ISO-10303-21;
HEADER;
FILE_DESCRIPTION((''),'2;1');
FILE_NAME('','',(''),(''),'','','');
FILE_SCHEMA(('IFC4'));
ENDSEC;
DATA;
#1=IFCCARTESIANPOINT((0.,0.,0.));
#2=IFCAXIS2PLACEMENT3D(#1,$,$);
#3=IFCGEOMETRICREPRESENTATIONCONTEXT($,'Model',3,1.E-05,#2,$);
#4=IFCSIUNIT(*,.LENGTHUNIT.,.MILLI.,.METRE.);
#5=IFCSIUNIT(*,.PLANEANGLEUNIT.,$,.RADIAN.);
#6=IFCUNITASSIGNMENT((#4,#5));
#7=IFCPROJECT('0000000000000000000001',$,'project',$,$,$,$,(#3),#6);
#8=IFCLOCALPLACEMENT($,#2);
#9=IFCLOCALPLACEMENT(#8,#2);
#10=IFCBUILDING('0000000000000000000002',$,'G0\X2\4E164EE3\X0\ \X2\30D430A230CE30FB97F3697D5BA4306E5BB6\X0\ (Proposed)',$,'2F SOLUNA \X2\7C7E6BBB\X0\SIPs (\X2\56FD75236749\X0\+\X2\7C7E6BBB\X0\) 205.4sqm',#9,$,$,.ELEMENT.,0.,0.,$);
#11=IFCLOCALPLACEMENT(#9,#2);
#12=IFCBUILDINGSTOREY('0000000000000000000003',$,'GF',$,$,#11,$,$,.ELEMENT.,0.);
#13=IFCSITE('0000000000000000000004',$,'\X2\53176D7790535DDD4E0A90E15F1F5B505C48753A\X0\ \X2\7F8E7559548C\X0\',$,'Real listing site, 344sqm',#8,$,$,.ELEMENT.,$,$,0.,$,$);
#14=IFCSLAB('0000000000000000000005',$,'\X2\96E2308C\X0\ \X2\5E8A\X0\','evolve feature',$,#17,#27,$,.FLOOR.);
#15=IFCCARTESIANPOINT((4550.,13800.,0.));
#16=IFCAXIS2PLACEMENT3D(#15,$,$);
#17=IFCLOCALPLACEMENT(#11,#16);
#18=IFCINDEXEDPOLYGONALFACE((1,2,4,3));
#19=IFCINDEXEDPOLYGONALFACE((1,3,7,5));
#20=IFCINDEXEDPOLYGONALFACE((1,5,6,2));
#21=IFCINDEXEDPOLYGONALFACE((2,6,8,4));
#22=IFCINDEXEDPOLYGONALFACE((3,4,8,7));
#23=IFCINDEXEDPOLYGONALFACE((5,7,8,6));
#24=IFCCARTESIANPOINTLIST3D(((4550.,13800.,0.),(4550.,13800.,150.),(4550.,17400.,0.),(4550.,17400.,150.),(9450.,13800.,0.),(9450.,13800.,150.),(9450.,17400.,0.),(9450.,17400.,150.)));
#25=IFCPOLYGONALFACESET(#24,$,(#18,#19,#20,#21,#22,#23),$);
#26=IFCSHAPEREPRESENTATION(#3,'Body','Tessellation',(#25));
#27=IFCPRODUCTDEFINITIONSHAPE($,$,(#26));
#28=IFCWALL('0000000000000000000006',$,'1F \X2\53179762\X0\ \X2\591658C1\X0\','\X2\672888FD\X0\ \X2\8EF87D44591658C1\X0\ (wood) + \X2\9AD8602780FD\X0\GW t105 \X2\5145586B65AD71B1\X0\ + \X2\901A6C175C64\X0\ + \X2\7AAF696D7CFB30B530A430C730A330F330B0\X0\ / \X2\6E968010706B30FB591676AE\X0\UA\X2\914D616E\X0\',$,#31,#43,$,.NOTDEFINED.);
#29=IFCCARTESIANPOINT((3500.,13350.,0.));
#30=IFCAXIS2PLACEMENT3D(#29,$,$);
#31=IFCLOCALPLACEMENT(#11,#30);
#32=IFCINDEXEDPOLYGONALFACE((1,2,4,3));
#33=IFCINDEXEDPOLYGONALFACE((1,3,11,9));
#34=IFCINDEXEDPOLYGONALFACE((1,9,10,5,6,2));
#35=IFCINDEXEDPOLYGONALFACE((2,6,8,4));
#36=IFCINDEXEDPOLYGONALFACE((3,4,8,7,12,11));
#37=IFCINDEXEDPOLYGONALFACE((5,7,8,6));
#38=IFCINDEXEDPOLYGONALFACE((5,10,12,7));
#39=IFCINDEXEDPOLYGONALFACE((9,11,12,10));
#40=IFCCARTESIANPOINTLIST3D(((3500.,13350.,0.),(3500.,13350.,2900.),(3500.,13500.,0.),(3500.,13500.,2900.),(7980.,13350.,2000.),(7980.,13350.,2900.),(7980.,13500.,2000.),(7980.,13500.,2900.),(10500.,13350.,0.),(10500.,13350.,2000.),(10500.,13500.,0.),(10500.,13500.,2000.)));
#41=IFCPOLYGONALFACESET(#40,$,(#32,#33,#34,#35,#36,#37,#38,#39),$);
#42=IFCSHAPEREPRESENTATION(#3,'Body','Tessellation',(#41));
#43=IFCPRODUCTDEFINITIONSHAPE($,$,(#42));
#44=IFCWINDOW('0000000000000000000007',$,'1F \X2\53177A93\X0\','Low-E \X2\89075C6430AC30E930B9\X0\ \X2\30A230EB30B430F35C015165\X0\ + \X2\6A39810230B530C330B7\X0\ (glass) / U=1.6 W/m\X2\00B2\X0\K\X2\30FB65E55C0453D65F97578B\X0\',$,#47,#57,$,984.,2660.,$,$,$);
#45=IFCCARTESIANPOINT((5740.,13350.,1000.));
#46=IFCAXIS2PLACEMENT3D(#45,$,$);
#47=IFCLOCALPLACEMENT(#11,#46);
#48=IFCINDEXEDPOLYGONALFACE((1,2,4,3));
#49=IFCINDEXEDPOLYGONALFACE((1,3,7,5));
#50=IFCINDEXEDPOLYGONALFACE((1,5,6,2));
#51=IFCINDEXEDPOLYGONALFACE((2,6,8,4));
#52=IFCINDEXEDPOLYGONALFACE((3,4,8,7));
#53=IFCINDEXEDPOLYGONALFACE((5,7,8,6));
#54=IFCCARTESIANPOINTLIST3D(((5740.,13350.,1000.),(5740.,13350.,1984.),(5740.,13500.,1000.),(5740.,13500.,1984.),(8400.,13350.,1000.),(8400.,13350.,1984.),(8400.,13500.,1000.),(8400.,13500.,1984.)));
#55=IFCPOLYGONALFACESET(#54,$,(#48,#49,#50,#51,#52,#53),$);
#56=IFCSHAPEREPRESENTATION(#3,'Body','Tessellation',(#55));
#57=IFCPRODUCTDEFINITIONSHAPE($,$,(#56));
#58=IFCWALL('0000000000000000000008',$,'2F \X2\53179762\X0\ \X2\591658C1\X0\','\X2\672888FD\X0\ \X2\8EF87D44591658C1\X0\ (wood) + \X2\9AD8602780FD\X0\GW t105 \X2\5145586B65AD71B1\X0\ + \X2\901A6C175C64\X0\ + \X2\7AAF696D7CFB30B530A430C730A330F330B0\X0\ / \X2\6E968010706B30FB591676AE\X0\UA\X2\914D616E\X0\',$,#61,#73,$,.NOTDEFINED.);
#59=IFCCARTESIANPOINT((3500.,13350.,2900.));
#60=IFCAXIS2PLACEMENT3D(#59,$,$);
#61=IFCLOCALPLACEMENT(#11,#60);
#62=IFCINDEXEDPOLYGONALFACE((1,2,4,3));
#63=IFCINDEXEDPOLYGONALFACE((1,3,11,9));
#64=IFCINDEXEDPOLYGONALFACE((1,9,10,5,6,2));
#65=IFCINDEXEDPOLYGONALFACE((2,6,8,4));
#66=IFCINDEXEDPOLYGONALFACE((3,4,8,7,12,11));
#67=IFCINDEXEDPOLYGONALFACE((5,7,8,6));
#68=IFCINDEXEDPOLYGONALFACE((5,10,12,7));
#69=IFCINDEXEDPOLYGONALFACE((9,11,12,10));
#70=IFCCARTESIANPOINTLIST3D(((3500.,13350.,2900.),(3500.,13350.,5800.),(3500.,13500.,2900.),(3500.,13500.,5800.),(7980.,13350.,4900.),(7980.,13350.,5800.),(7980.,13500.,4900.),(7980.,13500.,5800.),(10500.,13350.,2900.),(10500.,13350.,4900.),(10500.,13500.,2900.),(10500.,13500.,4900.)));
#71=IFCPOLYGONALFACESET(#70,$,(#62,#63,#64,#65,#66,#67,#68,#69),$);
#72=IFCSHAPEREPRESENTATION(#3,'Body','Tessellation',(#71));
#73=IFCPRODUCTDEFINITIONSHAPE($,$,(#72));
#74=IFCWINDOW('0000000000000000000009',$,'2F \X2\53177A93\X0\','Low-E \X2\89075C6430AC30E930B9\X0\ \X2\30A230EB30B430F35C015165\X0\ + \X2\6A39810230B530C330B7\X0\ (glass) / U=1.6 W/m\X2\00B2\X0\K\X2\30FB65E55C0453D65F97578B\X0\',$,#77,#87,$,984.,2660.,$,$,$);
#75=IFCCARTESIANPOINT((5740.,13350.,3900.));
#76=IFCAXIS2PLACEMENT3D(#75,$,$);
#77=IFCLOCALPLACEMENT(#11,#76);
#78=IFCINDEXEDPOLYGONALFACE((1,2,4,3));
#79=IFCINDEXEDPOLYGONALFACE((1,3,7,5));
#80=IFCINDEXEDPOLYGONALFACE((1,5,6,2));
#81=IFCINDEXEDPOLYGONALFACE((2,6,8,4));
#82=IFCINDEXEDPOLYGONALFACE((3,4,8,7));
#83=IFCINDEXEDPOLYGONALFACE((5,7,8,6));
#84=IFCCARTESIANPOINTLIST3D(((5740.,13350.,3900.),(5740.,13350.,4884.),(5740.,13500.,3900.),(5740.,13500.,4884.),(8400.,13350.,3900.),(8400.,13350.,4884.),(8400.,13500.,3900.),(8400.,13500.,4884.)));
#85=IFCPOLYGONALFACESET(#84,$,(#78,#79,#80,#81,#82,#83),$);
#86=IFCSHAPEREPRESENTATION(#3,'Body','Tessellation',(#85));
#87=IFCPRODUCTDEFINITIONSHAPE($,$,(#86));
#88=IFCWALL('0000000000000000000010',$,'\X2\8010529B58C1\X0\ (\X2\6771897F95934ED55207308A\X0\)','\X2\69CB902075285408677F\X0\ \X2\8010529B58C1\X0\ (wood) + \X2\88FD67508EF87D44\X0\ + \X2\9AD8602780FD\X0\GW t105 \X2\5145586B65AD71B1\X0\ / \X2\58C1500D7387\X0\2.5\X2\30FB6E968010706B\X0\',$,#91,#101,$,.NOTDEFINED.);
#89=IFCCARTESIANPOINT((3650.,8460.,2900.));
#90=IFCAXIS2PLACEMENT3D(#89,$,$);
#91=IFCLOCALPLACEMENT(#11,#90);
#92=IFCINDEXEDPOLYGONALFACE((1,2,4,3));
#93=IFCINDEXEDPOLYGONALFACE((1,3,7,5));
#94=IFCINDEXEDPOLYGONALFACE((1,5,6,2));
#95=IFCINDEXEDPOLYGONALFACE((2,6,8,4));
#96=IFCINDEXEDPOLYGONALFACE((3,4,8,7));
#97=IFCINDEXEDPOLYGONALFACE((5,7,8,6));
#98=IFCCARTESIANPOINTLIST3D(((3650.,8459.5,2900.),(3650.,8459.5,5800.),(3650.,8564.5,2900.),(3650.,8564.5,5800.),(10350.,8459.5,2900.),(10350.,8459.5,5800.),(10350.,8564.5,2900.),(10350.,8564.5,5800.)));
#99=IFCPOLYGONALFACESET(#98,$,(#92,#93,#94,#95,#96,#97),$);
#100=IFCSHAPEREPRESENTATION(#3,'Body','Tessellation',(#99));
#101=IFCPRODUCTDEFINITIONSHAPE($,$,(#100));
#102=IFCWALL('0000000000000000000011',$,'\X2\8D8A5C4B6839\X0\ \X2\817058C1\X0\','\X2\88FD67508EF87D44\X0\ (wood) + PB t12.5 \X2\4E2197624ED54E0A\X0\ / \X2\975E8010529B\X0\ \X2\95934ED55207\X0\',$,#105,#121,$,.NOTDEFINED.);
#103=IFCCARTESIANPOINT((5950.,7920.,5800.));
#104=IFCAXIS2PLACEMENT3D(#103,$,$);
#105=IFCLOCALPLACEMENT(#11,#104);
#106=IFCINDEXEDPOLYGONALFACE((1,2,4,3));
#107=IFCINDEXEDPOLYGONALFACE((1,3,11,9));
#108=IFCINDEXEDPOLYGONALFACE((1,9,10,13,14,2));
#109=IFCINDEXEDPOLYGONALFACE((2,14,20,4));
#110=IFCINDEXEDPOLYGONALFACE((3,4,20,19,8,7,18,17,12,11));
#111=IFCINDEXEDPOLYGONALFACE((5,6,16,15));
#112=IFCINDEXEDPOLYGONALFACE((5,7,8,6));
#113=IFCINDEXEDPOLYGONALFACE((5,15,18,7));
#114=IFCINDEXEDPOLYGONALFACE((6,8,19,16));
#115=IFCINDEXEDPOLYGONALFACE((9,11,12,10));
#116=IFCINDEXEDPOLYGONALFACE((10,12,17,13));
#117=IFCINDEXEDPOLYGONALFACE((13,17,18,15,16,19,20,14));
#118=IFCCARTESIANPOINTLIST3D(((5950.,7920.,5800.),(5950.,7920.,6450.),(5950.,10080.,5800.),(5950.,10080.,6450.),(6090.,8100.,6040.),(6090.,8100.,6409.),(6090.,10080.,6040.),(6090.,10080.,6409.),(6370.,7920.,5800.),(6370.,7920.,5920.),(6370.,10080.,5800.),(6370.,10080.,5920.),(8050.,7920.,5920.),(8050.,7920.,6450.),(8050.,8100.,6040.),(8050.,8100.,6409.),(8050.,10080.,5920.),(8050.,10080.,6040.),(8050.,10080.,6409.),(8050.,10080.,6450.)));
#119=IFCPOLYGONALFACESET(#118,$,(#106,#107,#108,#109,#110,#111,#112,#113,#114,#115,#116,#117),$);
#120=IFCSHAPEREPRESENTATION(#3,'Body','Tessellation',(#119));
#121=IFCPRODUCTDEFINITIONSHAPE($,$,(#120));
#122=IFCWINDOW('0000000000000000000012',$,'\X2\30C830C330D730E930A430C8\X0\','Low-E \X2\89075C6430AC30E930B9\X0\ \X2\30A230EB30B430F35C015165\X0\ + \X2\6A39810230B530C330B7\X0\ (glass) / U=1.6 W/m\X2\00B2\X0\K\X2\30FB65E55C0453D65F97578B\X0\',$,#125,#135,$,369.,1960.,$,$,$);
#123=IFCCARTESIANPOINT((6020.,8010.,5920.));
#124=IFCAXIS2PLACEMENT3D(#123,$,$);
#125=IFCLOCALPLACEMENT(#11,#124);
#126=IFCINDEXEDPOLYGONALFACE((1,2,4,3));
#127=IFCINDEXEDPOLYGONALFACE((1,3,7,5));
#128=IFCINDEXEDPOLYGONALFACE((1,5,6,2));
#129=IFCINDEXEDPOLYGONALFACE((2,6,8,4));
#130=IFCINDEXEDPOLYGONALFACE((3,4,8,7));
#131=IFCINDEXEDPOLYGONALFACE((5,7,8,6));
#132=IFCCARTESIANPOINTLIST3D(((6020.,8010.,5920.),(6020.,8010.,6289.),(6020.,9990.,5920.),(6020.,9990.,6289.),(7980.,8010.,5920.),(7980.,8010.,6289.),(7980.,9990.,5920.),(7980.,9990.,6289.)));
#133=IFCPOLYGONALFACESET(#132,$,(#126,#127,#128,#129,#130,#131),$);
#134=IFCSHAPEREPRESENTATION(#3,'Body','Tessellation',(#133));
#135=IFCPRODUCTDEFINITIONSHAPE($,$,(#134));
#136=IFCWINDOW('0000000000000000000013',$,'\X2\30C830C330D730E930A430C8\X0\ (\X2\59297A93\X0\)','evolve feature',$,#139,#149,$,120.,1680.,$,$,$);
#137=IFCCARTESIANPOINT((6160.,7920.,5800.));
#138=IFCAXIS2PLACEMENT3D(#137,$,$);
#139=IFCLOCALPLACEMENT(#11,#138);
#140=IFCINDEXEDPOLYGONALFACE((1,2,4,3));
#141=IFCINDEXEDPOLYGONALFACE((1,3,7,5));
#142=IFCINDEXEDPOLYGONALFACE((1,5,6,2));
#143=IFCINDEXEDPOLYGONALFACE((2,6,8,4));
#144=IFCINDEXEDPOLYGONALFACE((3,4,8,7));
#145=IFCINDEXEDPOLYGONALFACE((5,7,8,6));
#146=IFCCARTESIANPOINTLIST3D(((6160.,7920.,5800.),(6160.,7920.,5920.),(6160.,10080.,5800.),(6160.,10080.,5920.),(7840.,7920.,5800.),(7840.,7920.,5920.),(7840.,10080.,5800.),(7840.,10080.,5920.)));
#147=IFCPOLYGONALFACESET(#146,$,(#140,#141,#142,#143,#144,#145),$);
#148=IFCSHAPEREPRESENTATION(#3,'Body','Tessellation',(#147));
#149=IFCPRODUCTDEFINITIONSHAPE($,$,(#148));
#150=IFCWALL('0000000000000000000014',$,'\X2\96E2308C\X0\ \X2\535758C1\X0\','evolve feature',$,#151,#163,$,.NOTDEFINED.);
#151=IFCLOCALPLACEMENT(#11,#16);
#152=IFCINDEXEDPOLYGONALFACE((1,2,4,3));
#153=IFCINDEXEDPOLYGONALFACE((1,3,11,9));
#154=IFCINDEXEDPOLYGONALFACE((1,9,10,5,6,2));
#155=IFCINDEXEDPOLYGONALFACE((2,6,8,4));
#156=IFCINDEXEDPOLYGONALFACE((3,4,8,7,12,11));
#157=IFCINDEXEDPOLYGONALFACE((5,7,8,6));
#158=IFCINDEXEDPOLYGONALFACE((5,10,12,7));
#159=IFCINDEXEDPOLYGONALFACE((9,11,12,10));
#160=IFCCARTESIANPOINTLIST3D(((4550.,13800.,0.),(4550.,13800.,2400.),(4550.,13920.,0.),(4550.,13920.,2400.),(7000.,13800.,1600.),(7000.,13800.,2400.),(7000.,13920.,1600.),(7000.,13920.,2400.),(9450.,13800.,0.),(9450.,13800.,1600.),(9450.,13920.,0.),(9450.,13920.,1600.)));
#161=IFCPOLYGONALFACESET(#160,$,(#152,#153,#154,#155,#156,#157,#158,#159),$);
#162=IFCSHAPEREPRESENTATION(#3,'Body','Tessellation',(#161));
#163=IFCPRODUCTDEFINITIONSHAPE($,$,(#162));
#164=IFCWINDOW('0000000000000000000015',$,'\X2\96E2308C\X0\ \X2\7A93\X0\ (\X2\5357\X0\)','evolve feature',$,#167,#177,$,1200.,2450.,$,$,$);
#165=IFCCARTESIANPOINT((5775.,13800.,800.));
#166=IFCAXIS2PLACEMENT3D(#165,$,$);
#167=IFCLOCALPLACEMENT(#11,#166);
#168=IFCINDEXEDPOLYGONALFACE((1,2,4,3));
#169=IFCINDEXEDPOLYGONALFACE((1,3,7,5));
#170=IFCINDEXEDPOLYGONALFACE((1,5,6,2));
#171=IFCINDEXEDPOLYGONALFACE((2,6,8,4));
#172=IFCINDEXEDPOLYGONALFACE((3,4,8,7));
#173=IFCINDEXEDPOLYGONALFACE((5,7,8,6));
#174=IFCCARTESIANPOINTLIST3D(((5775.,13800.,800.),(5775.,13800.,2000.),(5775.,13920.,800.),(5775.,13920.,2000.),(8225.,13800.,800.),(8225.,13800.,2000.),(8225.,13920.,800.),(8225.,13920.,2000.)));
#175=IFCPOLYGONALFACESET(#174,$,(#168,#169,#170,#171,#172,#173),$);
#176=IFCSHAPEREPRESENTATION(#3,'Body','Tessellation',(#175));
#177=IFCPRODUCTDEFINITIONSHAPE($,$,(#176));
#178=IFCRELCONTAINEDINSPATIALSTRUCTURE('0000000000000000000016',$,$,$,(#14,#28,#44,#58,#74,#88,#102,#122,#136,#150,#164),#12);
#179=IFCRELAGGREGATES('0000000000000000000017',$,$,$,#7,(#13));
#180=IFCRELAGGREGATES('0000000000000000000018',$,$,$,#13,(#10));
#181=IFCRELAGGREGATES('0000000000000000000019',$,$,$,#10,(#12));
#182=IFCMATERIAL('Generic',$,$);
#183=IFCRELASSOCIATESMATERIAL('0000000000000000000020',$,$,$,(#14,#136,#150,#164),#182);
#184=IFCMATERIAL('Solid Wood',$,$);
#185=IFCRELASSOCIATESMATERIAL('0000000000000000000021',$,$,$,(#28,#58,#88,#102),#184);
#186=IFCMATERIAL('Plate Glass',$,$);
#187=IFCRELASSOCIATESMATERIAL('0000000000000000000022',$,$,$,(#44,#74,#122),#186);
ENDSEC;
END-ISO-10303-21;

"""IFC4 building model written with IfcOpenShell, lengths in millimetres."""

from ifc_helpers import new_model, si_unit, frame, frame_2d, origin, place, context, project, spatial, rectangle, extrude, material, element, fill, save


model = new_model("IFC4")

# Units and contexts
model_context = context("Model", 3, precision=1e-05, world=origin())
ifc_project = project(units=[si_unit("LENGTHUNIT", "METRE", prefix="MILLI"), si_unit("PLANEANGLEUNIT", "RADIAN")], contexts=[model_context])

# Site, building, storey
site_placement = place(None, origin())
site = spatial("IfcSite", under=ifc_project, at=site_placement, Name="北海道川上郡弟子屈町 美留和", ObjectType="Real listing site, 344sqm", CompositionType="ELEMENT", RefElevation=0.0)
building_placement = place(site_placement, origin())
building = spatial("IfcBuilding", under=site, at=building_placement, Name="G0世代 ピアノ・音楽室の家 (Proposed)", ObjectType="2F SOLUNA 籾殻SIPs (国産杉+籾殻) 205.4sqm", CompositionType="ELEMENT", ElevationOfRefHeight=0.0, ElevationOfTerrain=0.0)
storey_placement = place(building_placement, origin())
storey = spatial("IfcBuildingStorey", under=building, at=storey_placement, Name="GF", CompositionType="ELEMENT", Elevation=0.0)

# Slab
ifc_material_1 = material(Name="Generic")
slab_placement = place(storey_placement, frame((4550.0, 13800.0, 0.0)))
element("IfcSlab", 1, at=slab_placement, inside=storey, material=ifc_material_1, Name="離れ 床", Description="evolve feature", PredefinedType="FLOOR", context=model_context, shape_type="SweptSolid", body=[
    extrude(rectangle(XDim=4900.0, YDim=3600.0, at=frame_2d((2450.0, 1800.0))), frame((4550.0, 13800.0, 0.0)), (0.0, 0.0, 1.0), 150.0),
])

# Wall, opening, window
ifc_material_2 = material(Name="Solid Wood")
wall_1_placement = place(storey_placement, frame((3500.0, 13350.0, 0.0)))
wall_1 = element("IfcWall", 2, at=wall_1_placement, inside=storey, material=ifc_material_2, Name="1F 北面 外壁", Description="木製 軸組外壁 (wood) + 高性能GW t105 充填断熱 + 通気層 + 窯業系サイディング / 準耐火・外皮UA配慮", PredefinedType="NOTDEFINED", context=model_context, shape_type="SweptSolid", body=[
    extrude(rectangle(XDim=7000.0, YDim=150.0, at=frame_2d((3500.0, 75.0))), frame((3500.0, 13350.0, 0.0)), (0.0, 0.0, 1.0), 2900.0),
])
opening_1_placement = place(storey_placement, frame((5740.0, 13350.0, 1000.0)))
opening_1 = element("IfcOpeningElement", 3, at=opening_1_placement, cuts=wall_1, PredefinedType="NOTDEFINED", context=model_context, shape_type="SweptSolid", body=[
    extrude(rectangle(XDim=2660.0, YDim=150.0, at=frame_2d((1330.0, 75.0))), frame((5740.0, 13350.0, 1000.0)), (0.0, 0.0, 1.0), 984.0),
])
ifc_material_3 = material(Name="Plate Glass")
window_1_placement = place(storey_placement, frame((5740.0, 13350.0, 1000.0)))
window_1 = element("IfcWindow", 4, at=window_1_placement, inside=storey, material=ifc_material_3, Name="1F 北窓", Description="Low-E 複層ガラス アルゴン封入 + 樹脂サッシ (glass) / U=1.6 W/m²K・日射取得型", OverallHeight=984.0, OverallWidth=2660.0, context=model_context, shape_type="SweptSolid", body=[
    extrude(rectangle(XDim=2660.0, YDim=150.0, at=frame_2d((1330.0, 75.0))), frame((5740.0, 13350.0, 1000.0)), (0.0, 0.0, 1.0), 984.0),
])
fill(opening_1, window_1)

# Wall, opening, window
wall_2_placement = place(storey_placement, frame((3500.0, 13350.0, 2900.0)))
wall_2 = element("IfcWall", 5, at=wall_2_placement, inside=storey, material=ifc_material_2, Name="2F 北面 外壁", Description="木製 軸組外壁 (wood) + 高性能GW t105 充填断熱 + 通気層 + 窯業系サイディング / 準耐火・外皮UA配慮", PredefinedType="NOTDEFINED", context=model_context, shape_type="SweptSolid", body=[
    extrude(rectangle(XDim=7000.0, YDim=150.0, at=frame_2d((3500.0, 75.0))), frame((3500.0, 13350.0, 2900.0)), (0.0, 0.0, 1.0), 2900.0),
])
opening_2_placement = place(storey_placement, frame((5740.0, 13350.0, 3900.0)))
opening_2 = element("IfcOpeningElement", 6, at=opening_2_placement, cuts=wall_2, PredefinedType="NOTDEFINED", context=model_context, shape_type="SweptSolid", body=[
    extrude(rectangle(XDim=2660.0, YDim=150.0, at=frame_2d((1330.0, 75.0))), frame((5740.0, 13350.0, 3900.0)), (0.0, 0.0, 1.0), 984.0),
])
window_2_placement = place(storey_placement, frame((5740.0, 13350.0, 3900.0)))
window_2 = element("IfcWindow", 7, at=window_2_placement, inside=storey, material=ifc_material_3, Name="2F 北窓", Description="Low-E 複層ガラス アルゴン封入 + 樹脂サッシ (glass) / U=1.6 W/m²K・日射取得型", OverallHeight=984.0, OverallWidth=2660.0, context=model_context, shape_type="SweptSolid", body=[
    extrude(rectangle(XDim=2660.0, YDim=150.0, at=frame_2d((1330.0, 75.0))), frame((5740.0, 13350.0, 3900.0)), (0.0, 0.0, 1.0), 984.0),
])
fill(opening_2, window_2)

# Wall
wall_3_placement = place(storey_placement, frame((3650.0, 8460.0, 2900.0)))
element("IfcWall", 8, at=wall_3_placement, inside=storey, material=ifc_material_2, Name="耐力壁 (東西間仕切り)", Description="構造用合板 耐力壁 (wood) + 製材軸組 + 高性能GW t105 充填断熱 / 壁倍率2.5・準耐火", PredefinedType="NOTDEFINED", context=model_context, shape_type="SweptSolid", body=[
    extrude(rectangle(XDim=6700.0, YDim=105.0, at=frame_2d((3350.0, 52.0))), frame((3650.0, 8460.0, 2900.0)), (0.0, 0.0, 1.0), 2900.0),
])

# Wall, openings, windows
wall_4_placement = place(storey_placement, frame((5950.0, 7920.0, 5800.0)))
wall_4 = element("IfcWall", 9, at=wall_4_placement, inside=storey, material=ifc_material_2, Name="越屋根 腰壁", Description="製材軸組 (wood) + PB t12.5 両面仕上 / 非耐力 間仕切", PredefinedType="NOTDEFINED", context=model_context, shape_type="SweptSolid", body=[
    extrude(rectangle(XDim=2100.0, YDim=2160.0, at=frame_2d((1050.0, 1080.0))), frame((5950.0, 7920.0, 5800.0)), (0.0, 0.0, 1.0), 650.0),
])
opening_3_placement = place(storey_placement, frame((6020.0, 8010.0, 5920.0)))
opening_3 = element("IfcOpeningElement", 10, at=opening_3_placement, cuts=wall_4, PredefinedType="NOTDEFINED", context=model_context, shape_type="SweptSolid", body=[
    extrude(rectangle(XDim=1960.0, YDim=1980.0, at=frame_2d((980.0, 990.0))), frame((6020.0, 8010.0, 5920.0)), (0.0, 0.0, 1.0), 369.0),
])
opening_4_placement = place(storey_placement, frame((6160.0, 7920.0, 5800.0)))
opening_4 = element("IfcOpeningElement", 11, at=opening_4_placement, cuts=wall_4, PredefinedType="NOTDEFINED", context=model_context, shape_type="SweptSolid", body=[
    extrude(rectangle(XDim=1680.0, YDim=2160.0, at=frame_2d((840.0, 1080.0))), frame((6160.0, 7920.0, 5800.0)), (0.0, 0.0, 1.0), 120.0),
])
window_3_placement = place(storey_placement, frame((6020.0, 8010.0, 5920.0)))
window_3 = element("IfcWindow", 12, at=window_3_placement, inside=storey, material=ifc_material_3, Name="トップライト", Description="Low-E 複層ガラス アルゴン封入 + 樹脂サッシ (glass) / U=1.6 W/m²K・日射取得型", OverallHeight=369.0, OverallWidth=1960.0, context=model_context, shape_type="SweptSolid", body=[
    extrude(rectangle(XDim=1960.0, YDim=1980.0, at=frame_2d((980.0, 990.0))), frame((6020.0, 8010.0, 5920.0)), (0.0, 0.0, 1.0), 369.0),
])
fill(opening_3, window_3)
window_4_placement = place(storey_placement, frame((6160.0, 7920.0, 5800.0)))
window_4 = element("IfcWindow", 13, at=window_4_placement, inside=storey, material=ifc_material_1, Name="トップライト (天窓)", Description="evolve feature", OverallHeight=120.0, OverallWidth=1680.0, context=model_context, shape_type="SweptSolid", body=[
    extrude(rectangle(XDim=1680.0, YDim=2160.0, at=frame_2d((840.0, 1080.0))), frame((6160.0, 7920.0, 5800.0)), (0.0, 0.0, 1.0), 120.0),
])
fill(opening_4, window_4)

# Wall, opening, window
wall_5_placement = place(storey_placement, frame((4550.0, 13800.0, 0.0)))
wall_5 = element("IfcWall", 14, at=wall_5_placement, inside=storey, material=ifc_material_1, Name="離れ 南壁", Description="evolve feature", PredefinedType="NOTDEFINED", context=model_context, shape_type="SweptSolid", body=[
    extrude(rectangle(XDim=4900.0, YDim=120.0, at=frame_2d((2450.0, 60.0))), frame((4550.0, 13800.0, 0.0)), (0.0, 0.0, 1.0), 2400.0),
])
opening_5_placement = place(storey_placement, frame((5775.0, 13800.0, 800.0)))
opening_5 = element("IfcOpeningElement", 15, at=opening_5_placement, cuts=wall_5, PredefinedType="NOTDEFINED", context=model_context, shape_type="SweptSolid", body=[
    extrude(rectangle(XDim=2450.0, YDim=120.0, at=frame_2d((1225.0, 60.0))), frame((5775.0, 13800.0, 800.0)), (0.0, 0.0, 1.0), 1200.0),
])
window_5_placement = place(storey_placement, frame((5775.0, 13800.0, 800.0)))
window_5 = element("IfcWindow", 16, at=window_5_placement, inside=storey, material=ifc_material_1, Name="離れ 窓 (南)", Description="evolve feature", OverallHeight=1200.0, OverallWidth=2450.0, context=model_context, shape_type="SweptSolid", body=[
    extrude(rectangle(XDim=2450.0, YDim=120.0, at=frame_2d((1225.0, 60.0))), frame((5775.0, 13800.0, 800.0)), (0.0, 0.0, 1.0), 1200.0),
])
fill(opening_5, window_5)

save(model, "model.ifc")
